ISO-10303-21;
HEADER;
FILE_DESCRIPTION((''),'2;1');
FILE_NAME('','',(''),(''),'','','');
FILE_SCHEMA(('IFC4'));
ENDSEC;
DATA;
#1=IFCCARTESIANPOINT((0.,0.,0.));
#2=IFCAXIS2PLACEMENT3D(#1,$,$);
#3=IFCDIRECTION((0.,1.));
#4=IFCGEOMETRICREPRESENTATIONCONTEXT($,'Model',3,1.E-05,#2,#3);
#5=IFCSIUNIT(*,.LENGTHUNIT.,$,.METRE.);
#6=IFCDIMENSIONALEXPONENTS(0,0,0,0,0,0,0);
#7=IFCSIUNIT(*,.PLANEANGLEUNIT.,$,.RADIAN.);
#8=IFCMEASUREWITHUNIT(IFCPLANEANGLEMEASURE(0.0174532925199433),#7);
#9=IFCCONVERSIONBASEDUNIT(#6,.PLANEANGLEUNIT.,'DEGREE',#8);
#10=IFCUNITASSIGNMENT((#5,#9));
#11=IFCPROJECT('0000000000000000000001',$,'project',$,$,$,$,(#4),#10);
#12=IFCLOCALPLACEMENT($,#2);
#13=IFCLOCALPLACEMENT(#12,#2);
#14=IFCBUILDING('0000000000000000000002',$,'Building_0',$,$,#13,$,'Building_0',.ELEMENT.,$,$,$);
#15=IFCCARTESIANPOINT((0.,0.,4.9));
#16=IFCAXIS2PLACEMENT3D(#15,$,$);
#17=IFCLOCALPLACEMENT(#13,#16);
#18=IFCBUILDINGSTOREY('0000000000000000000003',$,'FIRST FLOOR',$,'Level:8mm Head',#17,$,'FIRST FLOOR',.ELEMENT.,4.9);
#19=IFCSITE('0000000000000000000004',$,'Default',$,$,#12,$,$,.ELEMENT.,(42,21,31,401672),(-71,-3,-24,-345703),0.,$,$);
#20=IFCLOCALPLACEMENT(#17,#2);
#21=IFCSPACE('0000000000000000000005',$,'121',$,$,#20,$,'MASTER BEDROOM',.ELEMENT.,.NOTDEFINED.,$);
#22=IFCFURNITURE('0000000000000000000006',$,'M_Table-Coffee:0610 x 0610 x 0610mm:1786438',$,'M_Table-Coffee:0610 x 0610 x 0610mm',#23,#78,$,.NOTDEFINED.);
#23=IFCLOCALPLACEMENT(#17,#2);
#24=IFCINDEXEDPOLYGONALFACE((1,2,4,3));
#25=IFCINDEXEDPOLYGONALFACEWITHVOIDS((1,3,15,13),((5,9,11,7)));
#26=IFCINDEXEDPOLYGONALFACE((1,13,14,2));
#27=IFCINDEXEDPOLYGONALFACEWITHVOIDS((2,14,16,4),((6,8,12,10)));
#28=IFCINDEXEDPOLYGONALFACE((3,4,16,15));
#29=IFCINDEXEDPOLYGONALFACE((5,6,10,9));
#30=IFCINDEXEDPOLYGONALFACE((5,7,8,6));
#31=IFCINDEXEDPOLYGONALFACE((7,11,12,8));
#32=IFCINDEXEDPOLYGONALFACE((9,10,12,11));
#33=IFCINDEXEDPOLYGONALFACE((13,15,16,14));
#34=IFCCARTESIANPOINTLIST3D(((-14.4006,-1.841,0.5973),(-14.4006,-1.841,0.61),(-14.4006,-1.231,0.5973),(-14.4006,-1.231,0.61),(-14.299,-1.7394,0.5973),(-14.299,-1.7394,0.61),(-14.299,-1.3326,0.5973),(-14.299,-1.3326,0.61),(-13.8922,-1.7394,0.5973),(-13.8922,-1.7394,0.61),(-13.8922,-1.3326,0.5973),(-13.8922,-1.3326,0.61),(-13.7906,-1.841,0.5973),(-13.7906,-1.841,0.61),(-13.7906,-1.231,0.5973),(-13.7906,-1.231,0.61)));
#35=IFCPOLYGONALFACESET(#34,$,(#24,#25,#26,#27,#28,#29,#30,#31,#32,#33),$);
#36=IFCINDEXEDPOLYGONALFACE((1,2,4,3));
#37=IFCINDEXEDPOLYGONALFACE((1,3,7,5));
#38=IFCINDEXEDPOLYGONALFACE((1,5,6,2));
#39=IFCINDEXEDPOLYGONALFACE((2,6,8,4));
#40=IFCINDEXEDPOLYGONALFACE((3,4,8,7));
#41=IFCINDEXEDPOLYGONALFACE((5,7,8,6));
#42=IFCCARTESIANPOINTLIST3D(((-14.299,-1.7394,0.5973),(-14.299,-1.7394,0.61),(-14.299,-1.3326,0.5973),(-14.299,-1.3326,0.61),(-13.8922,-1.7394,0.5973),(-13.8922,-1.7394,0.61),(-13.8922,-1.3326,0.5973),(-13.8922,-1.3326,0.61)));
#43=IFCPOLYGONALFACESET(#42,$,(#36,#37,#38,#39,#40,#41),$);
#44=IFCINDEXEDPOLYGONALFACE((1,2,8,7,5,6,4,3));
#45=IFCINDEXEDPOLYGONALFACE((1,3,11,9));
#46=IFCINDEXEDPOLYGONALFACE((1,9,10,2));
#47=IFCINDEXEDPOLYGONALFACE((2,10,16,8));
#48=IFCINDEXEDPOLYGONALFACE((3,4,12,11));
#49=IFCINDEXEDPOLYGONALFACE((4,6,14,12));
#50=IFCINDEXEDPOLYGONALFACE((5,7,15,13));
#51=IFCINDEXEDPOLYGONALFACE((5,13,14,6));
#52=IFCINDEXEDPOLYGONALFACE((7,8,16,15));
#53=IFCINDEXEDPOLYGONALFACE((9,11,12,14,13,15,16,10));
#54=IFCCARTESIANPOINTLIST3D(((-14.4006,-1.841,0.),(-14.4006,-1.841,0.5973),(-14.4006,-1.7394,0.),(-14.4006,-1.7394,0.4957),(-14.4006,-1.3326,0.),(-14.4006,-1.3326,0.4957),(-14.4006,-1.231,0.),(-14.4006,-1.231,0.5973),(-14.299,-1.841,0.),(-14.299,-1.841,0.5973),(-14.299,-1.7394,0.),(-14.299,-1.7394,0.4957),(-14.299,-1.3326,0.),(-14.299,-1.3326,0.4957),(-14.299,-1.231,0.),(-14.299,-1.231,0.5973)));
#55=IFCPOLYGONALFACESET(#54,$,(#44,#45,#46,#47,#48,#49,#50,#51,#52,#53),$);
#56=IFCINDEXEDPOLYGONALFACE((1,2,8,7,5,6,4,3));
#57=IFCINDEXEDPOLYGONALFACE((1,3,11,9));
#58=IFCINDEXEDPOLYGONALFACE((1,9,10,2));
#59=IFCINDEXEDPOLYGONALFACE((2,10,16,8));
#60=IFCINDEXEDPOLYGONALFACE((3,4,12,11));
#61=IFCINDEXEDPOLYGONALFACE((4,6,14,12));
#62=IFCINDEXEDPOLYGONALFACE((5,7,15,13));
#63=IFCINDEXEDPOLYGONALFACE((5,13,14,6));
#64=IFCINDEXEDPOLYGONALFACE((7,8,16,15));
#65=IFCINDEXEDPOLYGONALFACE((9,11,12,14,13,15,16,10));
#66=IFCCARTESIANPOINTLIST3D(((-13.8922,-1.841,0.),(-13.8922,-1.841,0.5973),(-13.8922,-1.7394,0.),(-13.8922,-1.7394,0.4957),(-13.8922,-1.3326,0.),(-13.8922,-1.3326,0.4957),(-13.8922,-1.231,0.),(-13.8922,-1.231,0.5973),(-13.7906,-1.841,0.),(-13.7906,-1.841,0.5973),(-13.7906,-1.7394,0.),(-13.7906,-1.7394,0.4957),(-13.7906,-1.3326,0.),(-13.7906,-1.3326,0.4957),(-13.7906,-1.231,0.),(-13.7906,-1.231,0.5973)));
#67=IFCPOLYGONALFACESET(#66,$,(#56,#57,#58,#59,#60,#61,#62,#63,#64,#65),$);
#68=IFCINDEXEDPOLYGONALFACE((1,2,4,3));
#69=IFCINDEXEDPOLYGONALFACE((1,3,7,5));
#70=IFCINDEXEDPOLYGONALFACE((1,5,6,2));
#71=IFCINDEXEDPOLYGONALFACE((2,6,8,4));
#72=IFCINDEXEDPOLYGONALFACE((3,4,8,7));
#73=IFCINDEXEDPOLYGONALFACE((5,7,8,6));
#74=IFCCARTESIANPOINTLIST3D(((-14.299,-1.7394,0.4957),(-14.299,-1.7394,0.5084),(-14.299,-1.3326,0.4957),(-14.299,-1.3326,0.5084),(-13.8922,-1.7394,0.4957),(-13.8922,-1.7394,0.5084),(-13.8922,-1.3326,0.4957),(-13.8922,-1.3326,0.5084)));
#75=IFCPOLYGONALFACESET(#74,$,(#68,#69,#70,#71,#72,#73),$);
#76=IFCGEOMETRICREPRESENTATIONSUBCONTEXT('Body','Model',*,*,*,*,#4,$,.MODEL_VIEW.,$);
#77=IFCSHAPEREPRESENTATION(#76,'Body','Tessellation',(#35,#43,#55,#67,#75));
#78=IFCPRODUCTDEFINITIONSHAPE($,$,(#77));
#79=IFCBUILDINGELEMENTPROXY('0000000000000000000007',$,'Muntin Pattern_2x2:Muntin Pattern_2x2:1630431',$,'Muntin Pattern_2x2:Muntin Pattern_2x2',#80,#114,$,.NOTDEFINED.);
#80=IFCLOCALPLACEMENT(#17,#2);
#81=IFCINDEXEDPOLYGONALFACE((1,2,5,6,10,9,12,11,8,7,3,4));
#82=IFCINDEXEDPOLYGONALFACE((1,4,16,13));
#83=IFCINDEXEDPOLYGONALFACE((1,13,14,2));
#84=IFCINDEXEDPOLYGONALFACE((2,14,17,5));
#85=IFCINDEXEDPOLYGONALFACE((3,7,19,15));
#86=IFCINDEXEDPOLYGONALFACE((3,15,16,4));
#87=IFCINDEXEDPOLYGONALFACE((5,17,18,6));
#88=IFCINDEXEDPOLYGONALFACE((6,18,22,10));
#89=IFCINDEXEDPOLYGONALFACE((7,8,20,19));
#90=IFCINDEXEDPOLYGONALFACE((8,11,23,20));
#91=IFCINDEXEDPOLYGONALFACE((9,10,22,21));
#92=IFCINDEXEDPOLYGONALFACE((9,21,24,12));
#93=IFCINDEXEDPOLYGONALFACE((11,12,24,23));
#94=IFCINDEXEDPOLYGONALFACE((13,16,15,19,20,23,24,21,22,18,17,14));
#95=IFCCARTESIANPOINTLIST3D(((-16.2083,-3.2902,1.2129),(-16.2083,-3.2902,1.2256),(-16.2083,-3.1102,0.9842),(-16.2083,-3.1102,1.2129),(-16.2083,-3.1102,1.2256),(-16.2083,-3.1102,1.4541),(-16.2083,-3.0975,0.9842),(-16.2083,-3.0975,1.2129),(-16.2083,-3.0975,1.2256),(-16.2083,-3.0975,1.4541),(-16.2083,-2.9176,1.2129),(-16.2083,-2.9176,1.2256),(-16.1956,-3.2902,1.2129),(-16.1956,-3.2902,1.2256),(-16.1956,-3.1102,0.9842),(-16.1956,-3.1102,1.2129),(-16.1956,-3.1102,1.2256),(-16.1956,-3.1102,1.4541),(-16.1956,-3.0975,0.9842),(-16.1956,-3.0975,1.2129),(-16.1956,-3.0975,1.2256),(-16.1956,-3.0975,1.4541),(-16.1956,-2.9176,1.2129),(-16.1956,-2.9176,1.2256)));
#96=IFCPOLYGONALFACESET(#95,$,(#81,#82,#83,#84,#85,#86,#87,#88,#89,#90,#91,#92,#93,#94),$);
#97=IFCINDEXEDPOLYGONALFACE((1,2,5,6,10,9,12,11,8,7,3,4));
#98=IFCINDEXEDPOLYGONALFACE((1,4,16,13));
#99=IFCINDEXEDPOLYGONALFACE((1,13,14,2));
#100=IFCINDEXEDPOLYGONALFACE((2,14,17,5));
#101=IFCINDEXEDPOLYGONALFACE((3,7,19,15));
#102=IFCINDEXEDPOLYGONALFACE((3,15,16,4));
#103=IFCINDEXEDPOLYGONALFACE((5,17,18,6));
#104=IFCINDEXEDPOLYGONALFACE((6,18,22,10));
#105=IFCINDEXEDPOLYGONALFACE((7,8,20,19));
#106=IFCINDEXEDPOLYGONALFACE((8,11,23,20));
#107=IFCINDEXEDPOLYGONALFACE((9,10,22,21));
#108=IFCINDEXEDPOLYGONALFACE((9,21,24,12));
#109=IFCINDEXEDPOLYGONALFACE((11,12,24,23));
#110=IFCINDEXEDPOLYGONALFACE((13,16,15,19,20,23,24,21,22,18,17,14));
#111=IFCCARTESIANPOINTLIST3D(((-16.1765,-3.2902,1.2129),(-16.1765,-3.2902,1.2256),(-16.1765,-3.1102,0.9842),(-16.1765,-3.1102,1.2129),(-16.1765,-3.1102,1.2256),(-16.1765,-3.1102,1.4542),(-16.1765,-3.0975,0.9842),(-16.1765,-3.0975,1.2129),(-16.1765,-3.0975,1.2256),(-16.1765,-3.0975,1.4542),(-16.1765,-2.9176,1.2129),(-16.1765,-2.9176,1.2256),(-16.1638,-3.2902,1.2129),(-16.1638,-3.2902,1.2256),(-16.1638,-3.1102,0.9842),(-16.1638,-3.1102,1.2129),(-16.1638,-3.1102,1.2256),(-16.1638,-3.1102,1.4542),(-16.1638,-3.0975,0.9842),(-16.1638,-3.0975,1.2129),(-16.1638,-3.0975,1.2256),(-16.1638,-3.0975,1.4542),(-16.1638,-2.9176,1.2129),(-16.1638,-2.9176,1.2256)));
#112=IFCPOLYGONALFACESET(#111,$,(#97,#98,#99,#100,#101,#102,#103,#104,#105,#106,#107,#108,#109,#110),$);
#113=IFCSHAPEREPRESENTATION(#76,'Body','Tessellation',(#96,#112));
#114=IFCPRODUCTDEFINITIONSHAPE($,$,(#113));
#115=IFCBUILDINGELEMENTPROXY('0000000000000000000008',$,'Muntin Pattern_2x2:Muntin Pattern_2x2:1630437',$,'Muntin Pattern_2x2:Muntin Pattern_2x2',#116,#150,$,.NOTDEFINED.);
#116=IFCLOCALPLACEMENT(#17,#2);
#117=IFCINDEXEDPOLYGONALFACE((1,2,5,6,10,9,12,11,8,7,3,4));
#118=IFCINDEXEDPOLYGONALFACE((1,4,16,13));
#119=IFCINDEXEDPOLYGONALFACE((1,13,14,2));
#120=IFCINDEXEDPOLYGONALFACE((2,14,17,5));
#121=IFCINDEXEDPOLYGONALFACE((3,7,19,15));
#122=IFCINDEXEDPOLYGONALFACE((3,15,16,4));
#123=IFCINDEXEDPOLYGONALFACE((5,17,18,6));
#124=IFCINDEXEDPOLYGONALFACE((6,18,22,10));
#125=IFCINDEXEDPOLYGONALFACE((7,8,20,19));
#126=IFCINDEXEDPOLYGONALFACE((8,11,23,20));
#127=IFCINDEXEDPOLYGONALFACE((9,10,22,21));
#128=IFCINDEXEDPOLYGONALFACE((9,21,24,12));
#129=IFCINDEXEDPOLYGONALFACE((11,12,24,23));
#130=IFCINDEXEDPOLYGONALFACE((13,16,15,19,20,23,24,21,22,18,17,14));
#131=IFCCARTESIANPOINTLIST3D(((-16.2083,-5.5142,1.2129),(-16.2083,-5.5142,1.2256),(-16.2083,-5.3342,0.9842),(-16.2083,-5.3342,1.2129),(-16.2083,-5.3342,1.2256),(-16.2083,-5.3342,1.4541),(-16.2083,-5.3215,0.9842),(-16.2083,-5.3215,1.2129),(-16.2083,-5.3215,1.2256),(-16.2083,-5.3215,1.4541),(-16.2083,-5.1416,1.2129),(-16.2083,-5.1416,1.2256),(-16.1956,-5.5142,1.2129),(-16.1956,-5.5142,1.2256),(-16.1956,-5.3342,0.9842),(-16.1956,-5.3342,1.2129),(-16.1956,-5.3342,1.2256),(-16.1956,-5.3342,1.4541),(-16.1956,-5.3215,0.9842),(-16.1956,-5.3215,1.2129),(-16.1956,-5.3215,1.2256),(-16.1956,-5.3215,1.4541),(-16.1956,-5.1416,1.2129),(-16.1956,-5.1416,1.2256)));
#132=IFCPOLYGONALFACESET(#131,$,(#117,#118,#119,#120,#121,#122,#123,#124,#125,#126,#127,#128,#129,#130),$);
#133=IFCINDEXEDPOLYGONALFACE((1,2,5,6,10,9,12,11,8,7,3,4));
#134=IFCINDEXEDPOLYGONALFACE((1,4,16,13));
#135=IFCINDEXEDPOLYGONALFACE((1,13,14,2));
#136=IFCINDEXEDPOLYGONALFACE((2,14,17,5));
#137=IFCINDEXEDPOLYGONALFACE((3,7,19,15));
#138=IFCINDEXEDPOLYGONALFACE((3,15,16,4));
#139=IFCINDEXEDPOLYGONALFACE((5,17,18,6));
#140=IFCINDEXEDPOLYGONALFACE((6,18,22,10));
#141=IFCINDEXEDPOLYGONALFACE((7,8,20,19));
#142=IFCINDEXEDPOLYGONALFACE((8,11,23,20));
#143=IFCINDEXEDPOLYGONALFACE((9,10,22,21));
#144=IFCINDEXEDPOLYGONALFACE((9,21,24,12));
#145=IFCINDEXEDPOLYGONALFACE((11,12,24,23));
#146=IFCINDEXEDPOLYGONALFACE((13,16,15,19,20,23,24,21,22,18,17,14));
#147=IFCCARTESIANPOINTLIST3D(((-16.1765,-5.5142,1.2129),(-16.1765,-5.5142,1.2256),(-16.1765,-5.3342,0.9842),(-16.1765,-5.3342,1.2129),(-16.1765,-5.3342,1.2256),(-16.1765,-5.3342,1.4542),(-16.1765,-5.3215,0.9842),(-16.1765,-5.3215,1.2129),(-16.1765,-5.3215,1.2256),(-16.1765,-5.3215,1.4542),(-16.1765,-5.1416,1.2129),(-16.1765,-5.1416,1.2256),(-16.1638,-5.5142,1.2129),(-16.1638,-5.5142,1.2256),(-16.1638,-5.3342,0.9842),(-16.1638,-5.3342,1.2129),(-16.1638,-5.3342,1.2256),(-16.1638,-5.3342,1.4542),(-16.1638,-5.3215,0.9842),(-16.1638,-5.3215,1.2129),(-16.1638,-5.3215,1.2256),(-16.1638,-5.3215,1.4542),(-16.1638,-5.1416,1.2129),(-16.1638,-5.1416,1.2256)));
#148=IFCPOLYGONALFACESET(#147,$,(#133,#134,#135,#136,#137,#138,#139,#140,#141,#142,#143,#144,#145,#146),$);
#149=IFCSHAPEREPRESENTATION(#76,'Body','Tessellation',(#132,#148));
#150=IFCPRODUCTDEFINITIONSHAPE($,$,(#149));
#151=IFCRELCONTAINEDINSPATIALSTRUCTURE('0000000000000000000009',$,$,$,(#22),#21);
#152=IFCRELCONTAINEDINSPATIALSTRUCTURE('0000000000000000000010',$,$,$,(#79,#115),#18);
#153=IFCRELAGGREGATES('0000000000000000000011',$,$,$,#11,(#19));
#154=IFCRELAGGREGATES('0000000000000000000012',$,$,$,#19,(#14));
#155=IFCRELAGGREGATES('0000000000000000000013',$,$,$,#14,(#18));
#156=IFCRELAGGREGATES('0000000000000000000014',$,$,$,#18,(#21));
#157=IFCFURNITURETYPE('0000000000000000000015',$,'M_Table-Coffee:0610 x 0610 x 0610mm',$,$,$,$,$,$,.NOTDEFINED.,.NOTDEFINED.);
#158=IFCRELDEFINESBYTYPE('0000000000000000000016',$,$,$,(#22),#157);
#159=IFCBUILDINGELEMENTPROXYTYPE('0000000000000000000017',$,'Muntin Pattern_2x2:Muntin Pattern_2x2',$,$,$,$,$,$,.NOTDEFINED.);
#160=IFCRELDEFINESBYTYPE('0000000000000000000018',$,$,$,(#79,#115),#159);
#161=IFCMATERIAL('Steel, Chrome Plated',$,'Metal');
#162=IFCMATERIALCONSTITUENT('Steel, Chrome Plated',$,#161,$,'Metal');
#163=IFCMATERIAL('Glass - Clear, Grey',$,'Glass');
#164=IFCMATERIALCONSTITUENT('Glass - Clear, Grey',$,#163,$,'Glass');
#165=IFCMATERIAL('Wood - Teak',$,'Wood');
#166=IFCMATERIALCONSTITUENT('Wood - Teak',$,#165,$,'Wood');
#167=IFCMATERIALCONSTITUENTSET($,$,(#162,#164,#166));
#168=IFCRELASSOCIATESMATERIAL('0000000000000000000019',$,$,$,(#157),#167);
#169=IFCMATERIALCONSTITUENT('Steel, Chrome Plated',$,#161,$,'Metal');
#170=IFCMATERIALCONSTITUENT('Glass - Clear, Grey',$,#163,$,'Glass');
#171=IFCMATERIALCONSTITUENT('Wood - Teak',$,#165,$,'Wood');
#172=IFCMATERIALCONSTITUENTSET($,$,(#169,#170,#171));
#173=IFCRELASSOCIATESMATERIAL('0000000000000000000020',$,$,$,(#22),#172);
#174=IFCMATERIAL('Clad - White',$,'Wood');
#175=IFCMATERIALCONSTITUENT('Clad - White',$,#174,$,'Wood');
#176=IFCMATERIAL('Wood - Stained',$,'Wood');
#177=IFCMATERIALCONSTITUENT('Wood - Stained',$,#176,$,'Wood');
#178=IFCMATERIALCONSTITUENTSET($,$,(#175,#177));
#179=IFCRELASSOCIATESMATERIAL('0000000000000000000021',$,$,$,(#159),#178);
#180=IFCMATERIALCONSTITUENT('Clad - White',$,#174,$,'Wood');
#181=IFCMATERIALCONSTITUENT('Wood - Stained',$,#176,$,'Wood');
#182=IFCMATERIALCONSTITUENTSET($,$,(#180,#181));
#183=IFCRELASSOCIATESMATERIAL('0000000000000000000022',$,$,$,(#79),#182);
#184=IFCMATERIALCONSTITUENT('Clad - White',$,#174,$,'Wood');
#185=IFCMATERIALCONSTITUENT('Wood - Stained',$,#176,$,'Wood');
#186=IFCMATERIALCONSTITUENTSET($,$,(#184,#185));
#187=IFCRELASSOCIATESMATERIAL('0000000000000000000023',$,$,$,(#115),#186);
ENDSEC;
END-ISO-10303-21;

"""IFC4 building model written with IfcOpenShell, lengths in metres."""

from ifc_helpers import new_model, entity, si_unit, converted_unit, direction, frame, origin, place, context, subcontext, project, spatial, indexed_curve, outline, extrude, source, transform, mapped, material, constituent, constituent_set, type_object, type_shapes, element, save


model = new_model("IFC4")

# Units and contexts
model_context = context("Model", 3, precision=1e-05, world=origin(), true_north=direction((0.0, 1.0)))
body_context = subcontext(model_context, "Body", "Model", "MODEL_VIEW")
ifc_project = project(units=[si_unit("LENGTHUNIT", "METRE"), converted_unit("PLANEANGLEUNIT", "DEGREE", entity("IfcPlaneAngleMeasure", 0.0174532925199433), si_unit("PLANEANGLEUNIT", "RADIAN"), dimensions=[0, 0, 0, 0, 0, 0, 0])], contexts=[model_context])

# Site, building, storey
site_placement = place(None, origin())
site = spatial("IfcSite", under=ifc_project, at=site_placement, Name="Default", CompositionType="ELEMENT", RefLatitude=(42, 21, 31, 401672), RefLongitude=(-71, -3, -24, -345703), RefElevation=0.0)
building_placement = place(site_placement, origin())
building = spatial("IfcBuilding", under=site, at=building_placement, Name="Building_0", LongName="Building_0", CompositionType="ELEMENT")
storey_placement = place(building_placement, frame((0.0, 0.0, 4.9)))
storey = spatial("IfcBuildingStorey", under=building, at=storey_placement, Name="FIRST FLOOR", ObjectType="Level:8mm Head", LongName="FIRST FLOOR", CompositionType="ELEMENT", Elevation=4.9)

# Shared definitions
ifc_material_1 = material(Name="Clad - White", Category="Wood")

# Shared definitions
space_placement = place(storey_placement, origin())
space = spatial("IfcSpace", under=storey, at=space_placement, Name="121", LongName="MASTER BEDROOM", CompositionType="ELEMENT", PredefinedType="NOTDEFINED")

# Furniture
ifc_material_2 = material(Name="Steel, Chrome Plated", Category="Metal")
ifc_constituent_1 = constituent(ifc_material_2, Name="Steel, Chrome Plated", Category="Metal")
ifc_material_3 = material(Name="Glass - Clear, Grey", Category="Glass")
ifc_constituent_2 = constituent(ifc_material_3, Name="Glass - Clear, Grey", Category="Glass")
ifc_material_4 = material(Name="Wood - Teak", Category="Wood")
ifc_constituent_3 = constituent(ifc_material_4, Name="Wood - Teak", Category="Wood")
ifc_constituent_set_1 = constituent_set(constituents=[ifc_constituent_1, ifc_constituent_2, ifc_constituent_3])
ifc_constituent_4 = constituent(ifc_material_2, Name="Steel, Chrome Plated", Category="Metal")
ifc_constituent_5 = constituent(ifc_material_3, Name="Glass - Clear, Grey", Category="Glass")
ifc_constituent_6 = constituent(ifc_material_4, Name="Wood - Teak", Category="Wood")
ifc_constituent_set_2 = constituent_set(constituents=[ifc_constituent_4, ifc_constituent_5, ifc_constituent_6])
furniture_type = type_object("IfcFurnitureType", Name="M_Table-Coffee:0610 x 0610 x 0610mm", AssemblyPlace="NOTDEFINED", PredefinedType="NOTDEFINED", material=ifc_constituent_set_2)
shared_shape_1 = source(origin(), body_context, "Body", "SweptSolid", [
    extrude(outline(indexed_curve([(-0.305, -0.305), (0.305, -0.305), (0.305, 0.305), (-0.305, 0.305), (-0.305, -0.305)], self_intersect=False), holes=[indexed_curve([(-0.2034, -0.2034), (-0.2034, 0.2034), (0.2034, 0.2034), (0.2034, -0.2034), (-0.2034, -0.2034)], self_intersect=False)]), frame((0.0183, 0.0952, 0.5973), z_axis=(0.0, 0.0, 1.0), x_axis=(-1.0, 0.0, 0.0)), (0.0, 0.0, 1.0), 0.0127),
    extrude(outline(indexed_curve([(-0.2034, -0.2034), (0.2034, -0.2034), (0.2034, 0.2034), (-0.2034, 0.2034), (-0.2034, -0.2034)], self_intersect=False)), frame((0.0183, 0.0952, 0.5973), z_axis=(0.0, 0.0, 1.0), x_axis=(-1.0, 0.0, 0.0)), (0.0, 0.0, 1.0), 0.0127),
    extrude(outline(indexed_curve([(-0.305, -0.3241), (0.305, -0.3241), (0.305, 0.2733), (0.2034, 0.2733), (0.2034, -0.2224), (-0.2034, -0.2224), (-0.2034, 0.2733), (-0.305, 0.2733), (-0.305, -0.3241)], self_intersect=False)), frame((-0.2867, 0.0952, 0.2733), z_axis=(1.0, 0.0, 0.0), x_axis=(0.0, -1.0, 0.0)), (0.0, 0.0, 1.0), 0.1016),
    extrude(outline(indexed_curve([(-0.2732, -0.305), (0.324, -0.305), (0.324, 0.305), (-0.2732, 0.305), (-0.2732, 0.2034), (0.2225, 0.2034), (0.2225, -0.2034), (-0.2732, -0.2034), (-0.2732, -0.305)], self_intersect=False)), frame((0.2217, 0.0952, 0.2732), z_axis=(1.0, 0.0, 0.0), x_axis=(0.0, 0.0, 1.0)), (0.0, 0.0, 1.0), 0.1016),
    extrude(outline(indexed_curve([(-0.2034, -0.2034), (0.2034, -0.2034), (0.2034, 0.2034), (-0.2034, 0.2034), (-0.2034, -0.2034)], self_intersect=False)), frame((0.0183, 0.0952, 0.4957), z_axis=(0.0, 0.0, 1.0), x_axis=(-1.0, 0.0, 0.0)), (0.0, 0.0, 1.0), 0.0127),
])
type_shapes(furniture_type, [shared_shape_1])
furniture_placement = place(space_placement, frame((-14.1139, -1.6312, 0.0)))
element("IfcFurniture", 1, at=furniture_placement, inside=space, type_object=furniture_type, material=ifc_constituent_set_1, Name="M_Table-Coffee:0610 x 0610 x 0610mm:1786438", ObjectType="M_Table-Coffee:0610 x 0610 x 0610mm", PredefinedType="NOTDEFINED", context=body_context, shape_type="MappedRepresentation", body=[
    mapped(shared_shape_1, transform((0.0, 0.0, 0.0), scale=1.0)),
])

# Building element proxies
ifc_constituent_7 = constituent(ifc_material_1, Name="Clad - White", Category="Wood")
ifc_material_5 = material(Name="Wood - Stained", Category="Wood")
ifc_constituent_8 = constituent(ifc_material_5, Name="Wood - Stained", Category="Wood")
ifc_constituent_set_3 = constituent_set(constituents=[ifc_constituent_7, ifc_constituent_8])
ifc_constituent_9 = constituent(ifc_material_1, Name="Clad - White", Category="Wood")
ifc_constituent_10 = constituent(ifc_material_5, Name="Wood - Stained", Category="Wood")
ifc_constituent_set_4 = constituent_set(constituents=[ifc_constituent_9, ifc_constituent_10])
building_element_proxy_type_1 = type_object("IfcBuildingElementProxyType", Name="Muntin Pattern_2x2:Muntin Pattern_2x2", PredefinedType="NOTDEFINED", material=ifc_constituent_set_4)
shared_shape_2 = source(origin(), body_context, "Body", "SweptSolid", [
    extrude(outline(indexed_curve([(0.0064, -0.0064), (0.2349, -0.0064), (0.2349, 0.0063), (0.0064, 0.0063), (0.0064, 0.1863), (-0.0063, 0.1863), (-0.0063, 0.0063), (-0.235, 0.0063), (-0.235, -0.0064), (-0.0063, -0.0064), (-0.0063, -0.1863), (0.0064, -0.1863), (0.0064, -0.0064)], self_intersect=False)), frame((0.0, 0.0095, 0.235), z_axis=(0.0, 1.0, 0.0), x_axis=(0.0, 0.0, 1.0)), (0.0, 0.0, 1.0), 0.0127),
    extrude(outline(indexed_curve([(0.0064, -0.0064), (0.235, -0.0064), (0.235, 0.0063), (0.0064, 0.0063), (0.0064, 0.1863), (-0.0063, 0.1863), (-0.0063, 0.0063), (-0.235, 0.0063), (-0.235, -0.0064), (-0.0063, -0.0064), (-0.0063, -0.1863), (0.0064, -0.1863), (0.0064, -0.0064)], self_intersect=False)), frame((0.0, -0.0222, 0.235), z_axis=(0.0, 1.0, 0.0), x_axis=(0.0, 0.0, 1.0)), (0.0, 0.0, 1.0), 0.0127),
])
type_shapes(building_element_proxy_type_1, [shared_shape_2])
proxy_1_placement = place(storey_placement, frame((-16.1861, -3.1039, 0.9842), z_axis=(0.0, 0.0, 1.0), x_axis=(0.0, 1.0, 0.0)))
element("IfcBuildingElementProxy", 2, at=proxy_1_placement, inside=storey, type_object=building_element_proxy_type_1, material=ifc_constituent_set_3, Name="Muntin Pattern_2x2:Muntin Pattern_2x2:1630431", ObjectType="Muntin Pattern_2x2:Muntin Pattern_2x2", PredefinedType="NOTDEFINED", context=body_context, shape_type="MappedRepresentation", body=[
    mapped(shared_shape_2, transform((0.0, 0.0, 0.0), scale=1.0)),
])
ifc_constituent_11 = constituent(ifc_material_1, Name="Clad - White", Category="Wood")
ifc_constituent_12 = constituent(ifc_material_5, Name="Wood - Stained", Category="Wood")
ifc_constituent_set_5 = constituent_set(constituents=[ifc_constituent_11, ifc_constituent_12])
proxy_2_placement = place(storey_placement, frame((-16.1861, -5.3279, 0.9842), z_axis=(0.0, 0.0, 1.0), x_axis=(0.0, 1.0, 0.0)))
element("IfcBuildingElementProxy", 3, at=proxy_2_placement, inside=storey, type_object=building_element_proxy_type_1, material=ifc_constituent_set_5, Name="Muntin Pattern_2x2:Muntin Pattern_2x2:1630437", ObjectType="Muntin Pattern_2x2:Muntin Pattern_2x2", PredefinedType="NOTDEFINED", context=body_context, shape_type="MappedRepresentation", body=[
    mapped(shared_shape_2, transform((0.0, 0.0, 0.0), scale=1.0)),
])

save(model, "model.ifc")
